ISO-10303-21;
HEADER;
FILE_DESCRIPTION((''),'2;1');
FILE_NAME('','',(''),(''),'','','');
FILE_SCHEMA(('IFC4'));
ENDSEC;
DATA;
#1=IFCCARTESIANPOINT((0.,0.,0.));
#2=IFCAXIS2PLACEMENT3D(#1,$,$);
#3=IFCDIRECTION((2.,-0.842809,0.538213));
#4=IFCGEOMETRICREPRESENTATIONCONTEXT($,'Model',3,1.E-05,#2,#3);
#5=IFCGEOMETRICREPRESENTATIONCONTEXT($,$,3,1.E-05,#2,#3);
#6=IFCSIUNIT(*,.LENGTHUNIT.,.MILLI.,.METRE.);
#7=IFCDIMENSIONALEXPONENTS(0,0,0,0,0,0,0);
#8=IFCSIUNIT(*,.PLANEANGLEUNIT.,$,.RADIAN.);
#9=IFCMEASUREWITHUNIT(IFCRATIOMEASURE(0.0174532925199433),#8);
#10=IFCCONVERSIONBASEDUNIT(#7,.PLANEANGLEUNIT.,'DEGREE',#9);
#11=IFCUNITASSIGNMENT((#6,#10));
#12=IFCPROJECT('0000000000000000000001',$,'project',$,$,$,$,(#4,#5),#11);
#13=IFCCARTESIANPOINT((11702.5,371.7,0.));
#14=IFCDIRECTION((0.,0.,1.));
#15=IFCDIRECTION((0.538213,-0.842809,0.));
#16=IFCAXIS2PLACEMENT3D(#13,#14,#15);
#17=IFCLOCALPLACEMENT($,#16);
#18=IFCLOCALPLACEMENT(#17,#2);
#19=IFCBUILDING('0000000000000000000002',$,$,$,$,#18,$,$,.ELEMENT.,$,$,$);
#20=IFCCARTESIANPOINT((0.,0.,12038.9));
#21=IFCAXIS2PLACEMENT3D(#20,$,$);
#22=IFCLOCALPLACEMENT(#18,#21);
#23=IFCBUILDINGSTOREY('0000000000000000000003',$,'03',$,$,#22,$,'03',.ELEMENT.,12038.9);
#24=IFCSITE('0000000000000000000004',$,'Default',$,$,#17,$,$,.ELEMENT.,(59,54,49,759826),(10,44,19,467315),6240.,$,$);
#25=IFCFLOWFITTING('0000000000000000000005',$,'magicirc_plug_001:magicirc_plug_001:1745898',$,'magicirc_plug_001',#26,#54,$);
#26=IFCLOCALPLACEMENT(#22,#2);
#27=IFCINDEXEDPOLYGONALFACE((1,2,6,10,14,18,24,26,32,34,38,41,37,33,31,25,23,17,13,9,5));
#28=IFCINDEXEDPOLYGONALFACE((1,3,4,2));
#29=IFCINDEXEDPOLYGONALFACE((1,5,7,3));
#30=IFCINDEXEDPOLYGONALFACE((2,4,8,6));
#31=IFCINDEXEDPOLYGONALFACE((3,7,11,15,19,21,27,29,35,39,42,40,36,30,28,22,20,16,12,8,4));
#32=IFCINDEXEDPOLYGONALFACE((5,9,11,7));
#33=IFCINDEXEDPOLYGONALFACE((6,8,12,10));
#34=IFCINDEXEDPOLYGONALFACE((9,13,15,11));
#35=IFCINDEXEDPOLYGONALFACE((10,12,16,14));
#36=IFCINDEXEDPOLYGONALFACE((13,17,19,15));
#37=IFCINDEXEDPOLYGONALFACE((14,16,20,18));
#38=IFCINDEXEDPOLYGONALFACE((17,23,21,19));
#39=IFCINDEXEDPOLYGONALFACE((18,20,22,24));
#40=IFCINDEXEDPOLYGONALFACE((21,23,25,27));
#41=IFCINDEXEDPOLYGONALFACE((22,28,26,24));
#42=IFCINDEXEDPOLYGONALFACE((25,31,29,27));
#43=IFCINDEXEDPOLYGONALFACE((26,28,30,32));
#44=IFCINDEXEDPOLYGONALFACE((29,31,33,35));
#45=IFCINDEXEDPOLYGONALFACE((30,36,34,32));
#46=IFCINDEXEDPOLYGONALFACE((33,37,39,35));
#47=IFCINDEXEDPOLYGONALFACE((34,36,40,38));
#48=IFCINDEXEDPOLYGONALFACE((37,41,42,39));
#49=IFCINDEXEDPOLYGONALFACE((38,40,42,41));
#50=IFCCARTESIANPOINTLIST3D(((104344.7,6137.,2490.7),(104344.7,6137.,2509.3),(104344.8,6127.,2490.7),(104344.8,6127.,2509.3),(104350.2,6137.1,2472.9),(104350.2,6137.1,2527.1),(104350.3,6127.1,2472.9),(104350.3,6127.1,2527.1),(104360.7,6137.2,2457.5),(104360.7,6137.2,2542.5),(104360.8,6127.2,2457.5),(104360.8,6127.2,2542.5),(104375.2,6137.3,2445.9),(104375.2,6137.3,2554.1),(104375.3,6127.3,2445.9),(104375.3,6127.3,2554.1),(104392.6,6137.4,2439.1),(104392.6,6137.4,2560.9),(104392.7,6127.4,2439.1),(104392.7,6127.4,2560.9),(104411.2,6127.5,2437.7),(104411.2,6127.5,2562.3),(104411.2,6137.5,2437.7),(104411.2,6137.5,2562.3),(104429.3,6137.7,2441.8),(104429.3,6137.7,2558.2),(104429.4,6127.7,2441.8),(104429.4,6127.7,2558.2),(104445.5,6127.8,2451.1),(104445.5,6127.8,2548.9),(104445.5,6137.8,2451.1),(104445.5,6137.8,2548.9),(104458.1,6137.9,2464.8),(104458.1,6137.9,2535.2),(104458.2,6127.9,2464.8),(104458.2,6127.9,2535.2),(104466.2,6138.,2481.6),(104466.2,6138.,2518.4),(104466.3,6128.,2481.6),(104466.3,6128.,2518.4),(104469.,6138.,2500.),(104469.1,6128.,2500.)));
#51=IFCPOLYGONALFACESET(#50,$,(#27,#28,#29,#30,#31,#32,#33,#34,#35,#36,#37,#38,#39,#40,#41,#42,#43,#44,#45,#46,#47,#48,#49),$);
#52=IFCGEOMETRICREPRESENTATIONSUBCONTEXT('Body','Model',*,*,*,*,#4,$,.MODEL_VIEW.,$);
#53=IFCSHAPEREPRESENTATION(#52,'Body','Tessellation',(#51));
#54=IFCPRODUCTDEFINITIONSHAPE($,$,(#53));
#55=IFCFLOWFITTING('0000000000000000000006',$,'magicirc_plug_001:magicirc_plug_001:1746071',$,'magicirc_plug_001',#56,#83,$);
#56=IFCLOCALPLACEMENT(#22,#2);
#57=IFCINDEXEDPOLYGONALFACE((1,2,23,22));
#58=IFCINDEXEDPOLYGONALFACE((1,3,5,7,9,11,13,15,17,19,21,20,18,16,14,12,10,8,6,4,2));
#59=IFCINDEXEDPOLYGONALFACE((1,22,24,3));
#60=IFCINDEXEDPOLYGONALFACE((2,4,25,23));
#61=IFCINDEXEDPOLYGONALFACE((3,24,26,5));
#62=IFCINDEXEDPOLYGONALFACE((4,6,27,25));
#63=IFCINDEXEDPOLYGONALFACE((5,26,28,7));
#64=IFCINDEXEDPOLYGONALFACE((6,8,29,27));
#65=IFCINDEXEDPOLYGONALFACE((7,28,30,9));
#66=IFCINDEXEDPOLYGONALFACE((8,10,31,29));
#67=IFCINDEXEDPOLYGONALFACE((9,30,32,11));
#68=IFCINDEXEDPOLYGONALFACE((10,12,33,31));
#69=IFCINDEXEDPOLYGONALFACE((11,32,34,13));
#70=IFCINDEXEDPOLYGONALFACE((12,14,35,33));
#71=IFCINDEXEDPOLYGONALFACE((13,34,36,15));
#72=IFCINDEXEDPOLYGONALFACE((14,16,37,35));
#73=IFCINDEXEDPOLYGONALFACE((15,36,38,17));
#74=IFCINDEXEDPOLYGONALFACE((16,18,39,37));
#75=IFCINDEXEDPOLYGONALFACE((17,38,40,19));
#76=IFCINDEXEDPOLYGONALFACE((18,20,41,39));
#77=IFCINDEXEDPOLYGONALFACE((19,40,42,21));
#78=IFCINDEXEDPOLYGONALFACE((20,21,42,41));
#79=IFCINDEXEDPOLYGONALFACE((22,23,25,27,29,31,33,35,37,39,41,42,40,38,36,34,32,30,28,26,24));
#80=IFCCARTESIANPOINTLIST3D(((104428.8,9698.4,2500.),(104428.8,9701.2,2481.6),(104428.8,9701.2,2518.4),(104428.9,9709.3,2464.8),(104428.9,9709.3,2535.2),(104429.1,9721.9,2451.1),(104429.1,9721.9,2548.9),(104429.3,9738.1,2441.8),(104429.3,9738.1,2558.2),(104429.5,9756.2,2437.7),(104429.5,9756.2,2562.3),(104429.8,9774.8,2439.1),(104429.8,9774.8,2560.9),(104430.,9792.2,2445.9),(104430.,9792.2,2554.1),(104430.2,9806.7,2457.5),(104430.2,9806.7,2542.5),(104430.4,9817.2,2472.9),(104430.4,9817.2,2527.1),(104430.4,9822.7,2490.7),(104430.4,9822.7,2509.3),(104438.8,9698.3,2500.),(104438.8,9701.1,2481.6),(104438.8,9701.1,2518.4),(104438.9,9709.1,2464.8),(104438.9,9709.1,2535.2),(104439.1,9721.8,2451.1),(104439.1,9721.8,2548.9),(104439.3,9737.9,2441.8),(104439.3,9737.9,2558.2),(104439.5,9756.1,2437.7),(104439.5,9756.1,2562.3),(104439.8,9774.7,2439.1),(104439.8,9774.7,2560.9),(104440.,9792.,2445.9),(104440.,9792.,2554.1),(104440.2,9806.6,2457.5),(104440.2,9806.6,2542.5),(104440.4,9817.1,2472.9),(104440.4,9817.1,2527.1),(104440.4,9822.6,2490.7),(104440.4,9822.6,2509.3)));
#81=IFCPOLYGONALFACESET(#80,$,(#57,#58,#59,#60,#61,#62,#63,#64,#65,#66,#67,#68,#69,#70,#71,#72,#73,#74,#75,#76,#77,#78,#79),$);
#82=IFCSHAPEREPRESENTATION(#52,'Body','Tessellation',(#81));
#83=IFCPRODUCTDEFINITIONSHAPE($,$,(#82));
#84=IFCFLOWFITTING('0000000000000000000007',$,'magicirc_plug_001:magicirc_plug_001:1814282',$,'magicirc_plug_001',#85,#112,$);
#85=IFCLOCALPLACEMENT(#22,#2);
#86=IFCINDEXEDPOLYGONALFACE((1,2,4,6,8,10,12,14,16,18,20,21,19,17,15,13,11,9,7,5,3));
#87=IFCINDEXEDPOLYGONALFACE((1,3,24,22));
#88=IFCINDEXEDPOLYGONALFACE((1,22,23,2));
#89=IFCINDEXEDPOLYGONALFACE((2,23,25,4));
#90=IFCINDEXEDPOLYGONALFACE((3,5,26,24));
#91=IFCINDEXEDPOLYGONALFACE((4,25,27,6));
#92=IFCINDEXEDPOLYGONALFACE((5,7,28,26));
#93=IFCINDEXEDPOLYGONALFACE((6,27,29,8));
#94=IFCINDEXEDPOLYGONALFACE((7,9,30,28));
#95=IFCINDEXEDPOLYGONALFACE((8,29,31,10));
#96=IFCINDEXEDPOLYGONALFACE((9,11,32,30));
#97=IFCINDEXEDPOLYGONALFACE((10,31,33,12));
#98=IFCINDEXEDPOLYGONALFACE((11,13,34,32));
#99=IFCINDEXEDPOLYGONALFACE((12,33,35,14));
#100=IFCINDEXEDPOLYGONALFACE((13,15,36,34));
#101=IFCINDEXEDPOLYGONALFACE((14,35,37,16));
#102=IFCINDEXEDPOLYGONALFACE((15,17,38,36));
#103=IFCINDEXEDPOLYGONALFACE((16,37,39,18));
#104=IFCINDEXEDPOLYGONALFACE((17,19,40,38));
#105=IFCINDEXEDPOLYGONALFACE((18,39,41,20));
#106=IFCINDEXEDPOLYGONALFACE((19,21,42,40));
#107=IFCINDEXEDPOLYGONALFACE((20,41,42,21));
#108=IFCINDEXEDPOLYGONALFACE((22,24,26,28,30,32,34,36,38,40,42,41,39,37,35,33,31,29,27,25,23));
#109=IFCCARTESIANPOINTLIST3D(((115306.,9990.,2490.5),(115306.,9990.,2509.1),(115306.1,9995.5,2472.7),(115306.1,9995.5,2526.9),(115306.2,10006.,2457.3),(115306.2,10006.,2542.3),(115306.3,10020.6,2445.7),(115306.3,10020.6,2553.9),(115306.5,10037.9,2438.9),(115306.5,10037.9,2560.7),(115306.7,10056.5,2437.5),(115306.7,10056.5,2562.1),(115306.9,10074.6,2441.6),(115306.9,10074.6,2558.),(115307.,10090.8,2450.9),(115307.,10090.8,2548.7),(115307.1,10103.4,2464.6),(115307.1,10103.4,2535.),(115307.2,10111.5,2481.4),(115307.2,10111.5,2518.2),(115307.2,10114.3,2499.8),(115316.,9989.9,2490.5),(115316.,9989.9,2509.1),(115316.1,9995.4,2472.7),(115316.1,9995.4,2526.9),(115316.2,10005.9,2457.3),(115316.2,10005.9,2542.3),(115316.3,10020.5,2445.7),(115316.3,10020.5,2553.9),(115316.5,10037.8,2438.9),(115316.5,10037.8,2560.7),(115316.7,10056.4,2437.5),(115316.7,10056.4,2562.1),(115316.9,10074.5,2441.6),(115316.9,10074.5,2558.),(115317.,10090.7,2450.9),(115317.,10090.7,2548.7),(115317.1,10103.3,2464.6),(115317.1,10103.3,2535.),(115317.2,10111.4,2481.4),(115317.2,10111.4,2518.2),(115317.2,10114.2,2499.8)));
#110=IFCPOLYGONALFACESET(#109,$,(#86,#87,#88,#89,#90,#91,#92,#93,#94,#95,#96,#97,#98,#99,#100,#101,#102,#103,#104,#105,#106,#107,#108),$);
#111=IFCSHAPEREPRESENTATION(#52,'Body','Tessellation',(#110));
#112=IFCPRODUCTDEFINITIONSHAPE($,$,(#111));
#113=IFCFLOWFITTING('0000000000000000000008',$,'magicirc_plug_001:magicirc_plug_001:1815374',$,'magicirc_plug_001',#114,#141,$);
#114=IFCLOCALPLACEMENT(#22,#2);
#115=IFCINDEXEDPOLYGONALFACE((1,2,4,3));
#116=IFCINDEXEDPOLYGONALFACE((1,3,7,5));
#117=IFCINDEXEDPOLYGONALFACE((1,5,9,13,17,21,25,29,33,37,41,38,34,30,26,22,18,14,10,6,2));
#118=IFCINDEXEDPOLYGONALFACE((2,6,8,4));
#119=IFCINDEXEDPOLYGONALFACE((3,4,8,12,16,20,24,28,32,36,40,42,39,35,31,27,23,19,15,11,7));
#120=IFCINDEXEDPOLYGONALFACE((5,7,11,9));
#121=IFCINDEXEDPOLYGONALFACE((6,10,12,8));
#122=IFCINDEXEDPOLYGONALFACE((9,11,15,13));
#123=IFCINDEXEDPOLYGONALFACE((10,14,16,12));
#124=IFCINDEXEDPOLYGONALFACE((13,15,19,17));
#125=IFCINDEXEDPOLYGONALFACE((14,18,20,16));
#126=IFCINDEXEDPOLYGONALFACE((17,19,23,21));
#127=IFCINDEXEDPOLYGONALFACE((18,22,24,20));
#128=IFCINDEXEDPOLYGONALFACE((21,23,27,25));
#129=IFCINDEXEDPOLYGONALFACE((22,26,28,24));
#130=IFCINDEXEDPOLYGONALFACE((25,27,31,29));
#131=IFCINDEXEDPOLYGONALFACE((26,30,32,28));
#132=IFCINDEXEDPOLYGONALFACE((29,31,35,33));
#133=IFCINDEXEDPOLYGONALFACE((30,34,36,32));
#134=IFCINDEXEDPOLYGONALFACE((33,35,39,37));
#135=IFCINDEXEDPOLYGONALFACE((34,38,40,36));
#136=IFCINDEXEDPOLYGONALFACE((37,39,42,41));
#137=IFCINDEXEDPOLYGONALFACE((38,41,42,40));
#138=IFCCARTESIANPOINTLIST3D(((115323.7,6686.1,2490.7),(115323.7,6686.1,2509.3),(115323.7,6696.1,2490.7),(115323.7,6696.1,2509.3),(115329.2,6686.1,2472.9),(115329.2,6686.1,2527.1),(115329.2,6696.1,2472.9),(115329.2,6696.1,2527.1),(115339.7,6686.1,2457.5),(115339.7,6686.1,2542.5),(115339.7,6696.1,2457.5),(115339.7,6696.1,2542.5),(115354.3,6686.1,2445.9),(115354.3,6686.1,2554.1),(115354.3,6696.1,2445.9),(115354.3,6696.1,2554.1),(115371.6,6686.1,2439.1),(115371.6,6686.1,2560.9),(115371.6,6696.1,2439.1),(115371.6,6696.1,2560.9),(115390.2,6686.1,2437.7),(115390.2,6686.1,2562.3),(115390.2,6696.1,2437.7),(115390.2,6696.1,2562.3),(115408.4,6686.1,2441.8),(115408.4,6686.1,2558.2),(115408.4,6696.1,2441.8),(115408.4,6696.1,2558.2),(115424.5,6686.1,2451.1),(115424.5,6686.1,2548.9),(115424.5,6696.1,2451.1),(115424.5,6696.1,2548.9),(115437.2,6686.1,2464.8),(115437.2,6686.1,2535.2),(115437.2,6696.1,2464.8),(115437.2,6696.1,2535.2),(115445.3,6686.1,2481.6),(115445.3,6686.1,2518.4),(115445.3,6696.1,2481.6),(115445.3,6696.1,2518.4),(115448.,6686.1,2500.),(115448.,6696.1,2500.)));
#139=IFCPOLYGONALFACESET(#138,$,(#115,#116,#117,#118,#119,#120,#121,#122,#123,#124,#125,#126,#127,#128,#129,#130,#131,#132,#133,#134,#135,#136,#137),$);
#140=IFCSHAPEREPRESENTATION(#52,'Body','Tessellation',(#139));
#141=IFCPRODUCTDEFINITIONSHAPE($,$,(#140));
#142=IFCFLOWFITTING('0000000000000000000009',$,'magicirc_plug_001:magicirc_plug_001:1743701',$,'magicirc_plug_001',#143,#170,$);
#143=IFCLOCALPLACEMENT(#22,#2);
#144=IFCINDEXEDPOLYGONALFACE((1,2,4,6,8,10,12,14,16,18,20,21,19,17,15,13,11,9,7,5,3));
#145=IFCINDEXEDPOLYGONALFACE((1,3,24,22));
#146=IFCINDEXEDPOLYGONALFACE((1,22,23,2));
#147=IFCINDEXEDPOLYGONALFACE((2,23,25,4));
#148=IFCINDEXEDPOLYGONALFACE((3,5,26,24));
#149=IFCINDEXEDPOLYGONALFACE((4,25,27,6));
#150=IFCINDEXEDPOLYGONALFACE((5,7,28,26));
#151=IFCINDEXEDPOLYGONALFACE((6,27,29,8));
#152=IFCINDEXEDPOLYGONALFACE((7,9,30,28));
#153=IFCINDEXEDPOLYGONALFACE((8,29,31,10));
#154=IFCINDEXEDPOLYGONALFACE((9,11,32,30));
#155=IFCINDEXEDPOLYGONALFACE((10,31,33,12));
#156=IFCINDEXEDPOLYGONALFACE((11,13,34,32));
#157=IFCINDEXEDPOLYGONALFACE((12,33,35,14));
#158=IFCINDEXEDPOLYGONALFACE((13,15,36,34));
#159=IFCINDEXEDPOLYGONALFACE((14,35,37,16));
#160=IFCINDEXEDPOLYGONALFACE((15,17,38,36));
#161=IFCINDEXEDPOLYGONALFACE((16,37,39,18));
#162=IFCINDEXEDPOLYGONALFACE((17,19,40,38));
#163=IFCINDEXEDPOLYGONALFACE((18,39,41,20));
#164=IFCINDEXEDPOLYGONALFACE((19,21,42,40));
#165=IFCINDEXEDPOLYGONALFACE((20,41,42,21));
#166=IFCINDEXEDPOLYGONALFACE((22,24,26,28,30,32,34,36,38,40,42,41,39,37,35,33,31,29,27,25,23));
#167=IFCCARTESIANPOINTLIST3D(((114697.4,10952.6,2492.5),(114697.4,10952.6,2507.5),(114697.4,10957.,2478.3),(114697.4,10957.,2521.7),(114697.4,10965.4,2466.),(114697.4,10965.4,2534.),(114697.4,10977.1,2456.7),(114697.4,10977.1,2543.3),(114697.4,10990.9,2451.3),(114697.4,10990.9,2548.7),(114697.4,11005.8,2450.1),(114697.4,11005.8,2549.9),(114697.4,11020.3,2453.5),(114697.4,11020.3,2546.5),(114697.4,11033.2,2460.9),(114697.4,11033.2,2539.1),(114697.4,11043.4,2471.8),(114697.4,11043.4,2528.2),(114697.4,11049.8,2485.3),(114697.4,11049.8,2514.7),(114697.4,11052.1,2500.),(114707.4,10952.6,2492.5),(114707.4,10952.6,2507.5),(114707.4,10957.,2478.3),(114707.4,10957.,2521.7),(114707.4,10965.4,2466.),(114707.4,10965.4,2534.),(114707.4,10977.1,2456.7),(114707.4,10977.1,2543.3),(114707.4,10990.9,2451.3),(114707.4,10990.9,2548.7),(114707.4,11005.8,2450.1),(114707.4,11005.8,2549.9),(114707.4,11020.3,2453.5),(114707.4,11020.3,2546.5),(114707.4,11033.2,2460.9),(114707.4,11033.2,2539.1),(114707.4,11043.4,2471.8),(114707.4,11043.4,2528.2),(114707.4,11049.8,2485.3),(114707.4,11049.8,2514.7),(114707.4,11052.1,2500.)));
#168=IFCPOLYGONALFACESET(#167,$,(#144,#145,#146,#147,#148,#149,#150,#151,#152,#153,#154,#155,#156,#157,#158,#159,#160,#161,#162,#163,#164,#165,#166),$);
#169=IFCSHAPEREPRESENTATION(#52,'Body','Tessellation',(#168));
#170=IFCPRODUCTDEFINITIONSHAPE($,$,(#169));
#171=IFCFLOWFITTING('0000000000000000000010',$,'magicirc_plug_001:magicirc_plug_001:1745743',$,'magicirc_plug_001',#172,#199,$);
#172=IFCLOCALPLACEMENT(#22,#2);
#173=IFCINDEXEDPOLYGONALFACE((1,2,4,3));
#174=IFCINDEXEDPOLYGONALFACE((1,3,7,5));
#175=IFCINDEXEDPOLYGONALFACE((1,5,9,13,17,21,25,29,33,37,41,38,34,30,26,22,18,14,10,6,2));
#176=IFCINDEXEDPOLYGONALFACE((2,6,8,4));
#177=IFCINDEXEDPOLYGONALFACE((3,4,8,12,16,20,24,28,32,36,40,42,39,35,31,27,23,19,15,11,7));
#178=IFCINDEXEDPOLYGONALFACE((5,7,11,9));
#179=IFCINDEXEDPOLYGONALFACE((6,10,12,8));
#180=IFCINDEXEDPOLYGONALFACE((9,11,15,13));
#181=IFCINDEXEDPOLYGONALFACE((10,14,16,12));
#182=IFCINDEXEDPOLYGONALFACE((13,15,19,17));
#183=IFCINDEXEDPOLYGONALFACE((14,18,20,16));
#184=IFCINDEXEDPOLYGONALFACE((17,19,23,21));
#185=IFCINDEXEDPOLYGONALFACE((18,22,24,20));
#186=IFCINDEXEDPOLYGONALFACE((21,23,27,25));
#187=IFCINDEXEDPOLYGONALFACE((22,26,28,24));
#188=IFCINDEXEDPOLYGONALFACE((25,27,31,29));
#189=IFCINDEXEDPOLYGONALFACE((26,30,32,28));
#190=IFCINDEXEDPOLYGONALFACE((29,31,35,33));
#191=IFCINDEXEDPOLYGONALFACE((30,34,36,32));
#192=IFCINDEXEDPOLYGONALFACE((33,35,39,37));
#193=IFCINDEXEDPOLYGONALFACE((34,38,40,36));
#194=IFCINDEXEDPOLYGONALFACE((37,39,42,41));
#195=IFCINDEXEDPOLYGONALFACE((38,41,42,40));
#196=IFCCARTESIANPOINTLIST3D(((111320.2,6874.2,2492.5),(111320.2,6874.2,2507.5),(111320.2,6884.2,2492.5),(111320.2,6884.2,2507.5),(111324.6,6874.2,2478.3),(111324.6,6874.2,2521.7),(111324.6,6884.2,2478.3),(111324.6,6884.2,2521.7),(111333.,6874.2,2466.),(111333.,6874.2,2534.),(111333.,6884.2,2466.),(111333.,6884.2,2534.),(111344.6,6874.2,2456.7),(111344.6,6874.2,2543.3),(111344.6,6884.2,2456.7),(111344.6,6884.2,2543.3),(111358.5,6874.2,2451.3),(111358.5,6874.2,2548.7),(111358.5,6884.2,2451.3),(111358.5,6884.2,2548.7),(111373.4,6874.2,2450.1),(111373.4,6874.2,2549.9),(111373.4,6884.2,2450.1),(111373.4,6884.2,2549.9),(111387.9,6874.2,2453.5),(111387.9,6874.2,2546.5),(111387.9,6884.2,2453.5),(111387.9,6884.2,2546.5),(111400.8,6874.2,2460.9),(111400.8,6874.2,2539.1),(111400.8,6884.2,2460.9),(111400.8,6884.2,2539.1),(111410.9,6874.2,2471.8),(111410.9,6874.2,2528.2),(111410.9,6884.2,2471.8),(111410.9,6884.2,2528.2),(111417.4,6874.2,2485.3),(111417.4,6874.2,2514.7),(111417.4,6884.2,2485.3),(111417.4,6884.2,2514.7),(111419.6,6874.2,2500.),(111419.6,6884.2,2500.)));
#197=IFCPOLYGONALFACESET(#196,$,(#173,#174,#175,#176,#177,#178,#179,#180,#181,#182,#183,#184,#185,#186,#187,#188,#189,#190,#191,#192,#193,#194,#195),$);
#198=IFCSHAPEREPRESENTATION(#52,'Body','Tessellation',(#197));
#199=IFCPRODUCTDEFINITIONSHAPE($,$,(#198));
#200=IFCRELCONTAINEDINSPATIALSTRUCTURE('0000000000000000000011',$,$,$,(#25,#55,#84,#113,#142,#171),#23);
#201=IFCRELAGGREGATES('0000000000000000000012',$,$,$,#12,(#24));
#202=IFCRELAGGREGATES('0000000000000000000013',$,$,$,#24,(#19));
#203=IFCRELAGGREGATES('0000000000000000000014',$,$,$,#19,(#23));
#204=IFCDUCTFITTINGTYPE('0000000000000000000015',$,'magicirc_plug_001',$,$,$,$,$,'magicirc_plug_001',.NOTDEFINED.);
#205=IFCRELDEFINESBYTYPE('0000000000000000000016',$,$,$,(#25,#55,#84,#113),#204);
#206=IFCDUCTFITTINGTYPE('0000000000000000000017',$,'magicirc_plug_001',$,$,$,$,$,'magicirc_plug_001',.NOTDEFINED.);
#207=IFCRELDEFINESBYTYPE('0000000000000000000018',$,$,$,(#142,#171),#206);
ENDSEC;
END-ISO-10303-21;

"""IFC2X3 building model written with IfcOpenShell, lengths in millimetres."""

from ifc_helpers import new_model, entity, si_unit, converted_unit, direction, frame, frame_2d, origin, place, context, subcontext, project, spatial, circle, extrude, source, transform, mapped, type_object, type_shapes, element, save


model = new_model("IFC2X3")

# Units and contexts
model_context = context("Model", 3, precision=1e-05, world=origin(), true_north=direction((2.0, -0.842809, 0.538213)))
context_of_model = context(None, 3, precision=1e-05, world=origin(), true_north=direction((2.0, -0.842809, 0.538213)))
body_context = subcontext(model_context, "Body", "Model", "MODEL_VIEW")
ifc_project = project(units=[si_unit("LENGTHUNIT", "METRE", prefix="MILLI"), converted_unit("PLANEANGLEUNIT", "DEGREE", entity("IfcRatioMeasure", 0.0174532925199433), si_unit("PLANEANGLEUNIT", "RADIAN"), dimensions=[0, 0, 0, 0, 0, 0, 0])], contexts=[model_context, context_of_model])

# Site, building, storey
site_placement = place(None, frame((11702.5, 371.7, 0.0), z_axis=(0.0, 0.0, 1.0), x_axis=(0.538213, -0.842809, 0.0)))
site = spatial("IfcSite", under=ifc_project, at=site_placement, Name="Default", CompositionType="ELEMENT", RefLatitude=(59, 54, 49, 759826), RefLongitude=(10, 44, 19, 467315), RefElevation=6240.0)
building_placement = place(site_placement, origin())
building = spatial("IfcBuilding", under=site, at=building_placement, CompositionType="ELEMENT")
storey_placement = place(building_placement, frame((0.0, 0.0, 12038.9)))
storey = spatial("IfcBuildingStorey", under=building, at=storey_placement, Name="03", LongName="03", CompositionType="ELEMENT", Elevation=12038.9)

# Flow fittings
duct_fitting_type_1 = type_object("IfcDuctFittingType", Name="magicirc_plug_001", ElementType="magicirc_plug_001", PredefinedType="NOTDEFINED")
shared_shape_1 = source(origin(), body_context, "Body", "SweptSolid", [
    extrude(circle(Radius=62.5, at=frame_2d((0.0, 0.0), x_axis=(1.0, 0.0))), frame((0.0, 0.0, 0.0), z_axis=(1.0, 0.0, 0.0), x_axis=(0.0, 1.0, 0.0)), (0.0, 0.0, 1.0), 10.0),
])
type_shapes(duct_fitting_type_1, [shared_shape_1])
for number, where, z_axis, x_axis, name in (
    (1, (104406.5, 6137.5, 2500.0), (0.0, 0.0, 1.0), (0.007643, -0.999971, 0.0), "magicirc_plug_001:magicirc_plug_001:1745898"),
    (2, (104439.6, 9760.8, 2500.0), (0.0, 0.0, 1.0), (-0.999911, 0.013345, 0.0), "magicirc_plug_001:magicirc_plug_001:1746071"),
    (3, (115306.6, 10051.8, 2499.8), (-0.000017, 0.0, 1.0), (0.999952, -0.00981, 0.000017), "magicirc_plug_001:magicirc_plug_001:1814282"),
    (4, (115385.5, 6696.1, 2500.0), (0.0, 0.0, 1.0), (0.0, -1.0, 0.0), "magicirc_plug_001:magicirc_plug_001:1815374"),
):
    element("IfcFlowFitting", number, at=place(storey_placement, frame(where, z_axis=z_axis, x_axis=x_axis)), inside=storey, type_object=duct_fitting_type_1, Name=name, ObjectType="magicirc_plug_001", context=body_context, shape_type="MappedRepresentation", body=[
        mapped(shared_shape_1, transform((0.0, 0.0, 0.0), scale=1.0)),
    ])

# Flow fittings
duct_fitting_type_2 = type_object("IfcDuctFittingType", Name="magicirc_plug_001", ElementType="magicirc_plug_001", PredefinedType="NOTDEFINED")
shared_shape_2 = source(origin(), body_context, "Body", "SweptSolid", [
    extrude(circle(Radius=50.0, at=frame_2d((0.0, 0.0), x_axis=(1.0, 0.0))), frame((0.0, 0.0, 0.0), z_axis=(1.0, 0.0, 0.0), x_axis=(0.0, 1.0, 0.0)), (0.0, 0.0, 1.0), 10.0),
])
type_shapes(duct_fitting_type_2, [shared_shape_2])
flow_fitting_placement = place(storey_placement, frame((114697.4, 11002.1, 2500.0)))
element("IfcFlowFitting", 5, at=flow_fitting_placement, inside=storey, type_object=duct_fitting_type_2, Name="magicirc_plug_001:magicirc_plug_001:1743701", ObjectType="magicirc_plug_001", context=body_context, shape_type="MappedRepresentation", body=[
    mapped(shared_shape_2, transform((0.0, 0.0, 0.0), scale=1.0)),
])
for number, where, z_axis, x_axis, name in (
    (6, (111369.6, 6884.2, 2500.0), (0.0, 0.0, 1.0), (0.0, -1.0, 0.0), "magicirc_plug_001:magicirc_plug_001:1745743"),
):
    element("IfcFlowFitting", number, at=place(storey_placement, frame(where, z_axis=z_axis, x_axis=x_axis)), inside=storey, type_object=duct_fitting_type_2, Name=name, ObjectType="magicirc_plug_001", context=body_context, shape_type="MappedRepresentation", body=[
        mapped(shared_shape_2, transform((0.0, 0.0, 0.0), scale=1.0)),
    ])

save(model, "model.ifc")
